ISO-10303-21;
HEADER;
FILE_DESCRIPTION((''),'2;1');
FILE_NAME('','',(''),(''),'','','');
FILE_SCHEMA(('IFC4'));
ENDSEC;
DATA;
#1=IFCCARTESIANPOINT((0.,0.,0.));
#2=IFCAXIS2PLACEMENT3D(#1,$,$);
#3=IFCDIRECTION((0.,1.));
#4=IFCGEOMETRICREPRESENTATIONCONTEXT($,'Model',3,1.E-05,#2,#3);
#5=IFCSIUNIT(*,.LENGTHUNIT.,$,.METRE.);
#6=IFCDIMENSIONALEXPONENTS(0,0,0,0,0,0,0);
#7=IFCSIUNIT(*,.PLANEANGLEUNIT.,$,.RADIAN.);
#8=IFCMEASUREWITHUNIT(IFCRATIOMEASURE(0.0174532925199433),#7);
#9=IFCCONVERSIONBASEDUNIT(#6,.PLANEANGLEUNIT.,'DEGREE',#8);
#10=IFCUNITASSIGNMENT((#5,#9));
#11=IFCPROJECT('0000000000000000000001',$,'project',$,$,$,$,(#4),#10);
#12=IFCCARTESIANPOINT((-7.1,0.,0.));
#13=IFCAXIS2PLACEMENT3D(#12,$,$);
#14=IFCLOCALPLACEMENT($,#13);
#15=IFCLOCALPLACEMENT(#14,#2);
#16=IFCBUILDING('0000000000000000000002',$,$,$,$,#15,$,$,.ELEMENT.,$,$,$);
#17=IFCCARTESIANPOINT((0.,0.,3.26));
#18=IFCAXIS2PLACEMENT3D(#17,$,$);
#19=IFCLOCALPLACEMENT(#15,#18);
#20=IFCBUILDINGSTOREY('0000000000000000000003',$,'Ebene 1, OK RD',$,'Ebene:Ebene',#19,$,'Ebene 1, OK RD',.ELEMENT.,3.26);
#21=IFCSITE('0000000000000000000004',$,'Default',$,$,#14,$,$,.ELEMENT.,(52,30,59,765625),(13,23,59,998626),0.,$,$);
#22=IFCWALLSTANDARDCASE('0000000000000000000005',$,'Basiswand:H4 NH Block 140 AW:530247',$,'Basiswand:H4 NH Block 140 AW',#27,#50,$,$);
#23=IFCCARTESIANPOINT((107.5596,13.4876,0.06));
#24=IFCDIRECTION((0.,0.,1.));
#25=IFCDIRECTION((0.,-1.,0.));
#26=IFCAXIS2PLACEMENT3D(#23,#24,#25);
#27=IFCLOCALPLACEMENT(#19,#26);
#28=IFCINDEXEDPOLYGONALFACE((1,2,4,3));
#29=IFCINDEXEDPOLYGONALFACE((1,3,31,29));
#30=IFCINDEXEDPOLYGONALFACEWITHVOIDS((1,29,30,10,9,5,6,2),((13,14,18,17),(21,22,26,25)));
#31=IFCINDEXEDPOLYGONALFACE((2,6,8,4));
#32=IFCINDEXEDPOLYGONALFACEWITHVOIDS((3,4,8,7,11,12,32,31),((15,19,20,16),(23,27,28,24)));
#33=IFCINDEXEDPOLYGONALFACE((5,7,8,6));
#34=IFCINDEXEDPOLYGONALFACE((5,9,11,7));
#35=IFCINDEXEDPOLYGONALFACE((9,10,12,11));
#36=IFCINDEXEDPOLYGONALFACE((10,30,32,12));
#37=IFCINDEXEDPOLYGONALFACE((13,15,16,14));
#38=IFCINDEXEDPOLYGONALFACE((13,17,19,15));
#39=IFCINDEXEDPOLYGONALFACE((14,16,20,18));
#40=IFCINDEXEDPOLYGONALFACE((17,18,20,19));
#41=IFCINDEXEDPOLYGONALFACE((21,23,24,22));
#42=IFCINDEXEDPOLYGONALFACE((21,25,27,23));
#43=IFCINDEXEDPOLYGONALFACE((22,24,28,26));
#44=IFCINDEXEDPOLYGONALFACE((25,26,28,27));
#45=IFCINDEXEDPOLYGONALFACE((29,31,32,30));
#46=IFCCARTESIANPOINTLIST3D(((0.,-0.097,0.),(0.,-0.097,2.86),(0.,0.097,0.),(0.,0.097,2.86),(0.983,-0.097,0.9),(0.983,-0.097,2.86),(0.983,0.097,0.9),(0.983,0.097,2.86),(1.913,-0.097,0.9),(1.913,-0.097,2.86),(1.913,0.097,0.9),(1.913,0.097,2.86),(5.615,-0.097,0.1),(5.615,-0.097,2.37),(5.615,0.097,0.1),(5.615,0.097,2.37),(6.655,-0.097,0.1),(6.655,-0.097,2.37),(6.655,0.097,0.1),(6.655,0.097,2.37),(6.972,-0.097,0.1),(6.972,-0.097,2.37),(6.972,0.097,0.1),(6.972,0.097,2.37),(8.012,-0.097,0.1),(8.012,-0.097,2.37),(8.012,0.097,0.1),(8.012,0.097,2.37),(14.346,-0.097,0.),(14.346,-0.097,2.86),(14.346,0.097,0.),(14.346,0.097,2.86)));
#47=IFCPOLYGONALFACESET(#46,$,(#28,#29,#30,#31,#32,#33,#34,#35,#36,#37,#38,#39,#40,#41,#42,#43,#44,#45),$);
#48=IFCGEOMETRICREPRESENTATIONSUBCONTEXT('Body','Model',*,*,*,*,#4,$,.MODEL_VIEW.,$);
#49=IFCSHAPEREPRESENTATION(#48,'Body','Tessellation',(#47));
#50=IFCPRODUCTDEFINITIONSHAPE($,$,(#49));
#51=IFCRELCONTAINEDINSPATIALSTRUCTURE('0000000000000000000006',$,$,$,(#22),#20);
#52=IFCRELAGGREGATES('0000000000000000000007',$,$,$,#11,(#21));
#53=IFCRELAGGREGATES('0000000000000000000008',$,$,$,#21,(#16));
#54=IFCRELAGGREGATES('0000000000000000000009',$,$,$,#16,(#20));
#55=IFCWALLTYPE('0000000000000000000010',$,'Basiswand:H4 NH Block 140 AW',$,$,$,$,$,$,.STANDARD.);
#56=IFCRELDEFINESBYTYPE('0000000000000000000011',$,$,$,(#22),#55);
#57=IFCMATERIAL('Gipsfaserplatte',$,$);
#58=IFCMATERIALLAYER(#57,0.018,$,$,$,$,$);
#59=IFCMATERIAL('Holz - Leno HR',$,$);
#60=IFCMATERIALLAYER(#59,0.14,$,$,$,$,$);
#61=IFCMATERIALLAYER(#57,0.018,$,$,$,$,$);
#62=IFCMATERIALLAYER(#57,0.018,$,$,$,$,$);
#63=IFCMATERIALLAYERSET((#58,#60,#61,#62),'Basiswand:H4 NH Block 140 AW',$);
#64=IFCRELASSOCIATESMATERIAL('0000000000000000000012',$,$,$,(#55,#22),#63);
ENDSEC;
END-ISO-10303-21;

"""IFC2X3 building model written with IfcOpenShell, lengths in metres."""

from ifc_helpers import new_model, entity, si_unit, converted_unit, direction, frame, frame_2d, origin, place, context, subcontext, project, spatial, rectangle, extrude, material, layer, layer_set, layer_usage, type_object, element, save


model = new_model("IFC2X3")

# Units and contexts
model_context = context("Model", 3, precision=1e-05, world=origin(), true_north=direction((0.0, 1.0)))
body_context = subcontext(model_context, "Body", "Model", "MODEL_VIEW")
ifc_project = project(units=[si_unit("LENGTHUNIT", "METRE"), converted_unit("PLANEANGLEUNIT", "DEGREE", entity("IfcRatioMeasure", 0.0174532925199433), si_unit("PLANEANGLEUNIT", "RADIAN"), dimensions=[0, 0, 0, 0, 0, 0, 0])], contexts=[model_context])

# Site, building, storey
site_placement = place(None, frame((-7.1, 0.0, 0.0)))
site = spatial("IfcSite", under=ifc_project, at=site_placement, Name="Default", CompositionType="ELEMENT", RefLatitude=(52, 30, 59, 765625), RefLongitude=(13, 23, 59, 998626), RefElevation=0.0)
building_placement = place(site_placement, origin())
building = spatial("IfcBuilding", under=site, at=building_placement, CompositionType="ELEMENT")
storey_placement = place(building_placement, frame((0.0, 0.0, 3.26)))
storey = spatial("IfcBuildingStorey", under=building, at=storey_placement, Name="Ebene 1, OK RD", ObjectType="Ebene:Ebene", LongName="Ebene 1, OK RD", CompositionType="ELEMENT", Elevation=3.26)

# Wall, openings
ifc_material_1 = material(Name="Gipsfaserplatte")
ifc_layer_1 = layer(ifc_material_1, 0.018)
ifc_material_2 = material(Name="Holz - Leno HR")
ifc_layer_2 = layer(ifc_material_2, 0.14)
ifc_layer_3 = layer(ifc_material_1, 0.018)
ifc_layer_4 = layer(ifc_material_1, 0.018)
ifc_layer_set_1 = layer_set([ifc_layer_1, ifc_layer_2, ifc_layer_3, ifc_layer_4], Name="Basiswand:H4 NH Block 140 AW")
ifc_layer_usage_1 = layer_usage(ifc_layer_set_1, "AXIS2", "NEGATIVE", 0.097)
wall_type_1 = type_object("IfcWallType", Name="Basiswand:H4 NH Block 140 AW", PredefinedType="STANDARD", material=ifc_layer_set_1)
wall_1_placement = place(storey_placement, frame((107.5596, 13.4876, 0.06), z_axis=(0.0, 0.0, 1.0), x_axis=(0.0, -1.0, 0.0)))
wall_1 = element("IfcWallStandardCase", 1, at=wall_1_placement, inside=storey, type_object=wall_type_1, material=ifc_layer_usage_1, Name="Basiswand:H4 NH Block 140 AW:530247", ObjectType="Basiswand:H4 NH Block 140 AW", context=body_context, shape_type="SweptSolid", body=[
    extrude(rectangle(XDim=14.346, YDim=0.194, at=frame_2d((7.173, 0.0), x_axis=(-1.0, 0.0))), origin(), (0.0, 0.0, 1.0), 2.86),
])
opening_1_placement = place(wall_1_placement, origin())
element("IfcOpeningElement", 2, at=opening_1_placement, cuts=wall_1, ObjectType="Opening", context=body_context, shape_type="SweptSolid", body=[
    extrude(rectangle(XDim=2.27, YDim=1.04, at=frame_2d((0.0, 0.0), x_axis=(1.0, 0.0))), frame((7.492, -0.097, 1.235), z_axis=(0.0, 1.0, 0.0), x_axis=(0.0, 0.0, -1.0)), (0.0, 0.0, 1.0), 0.194),
])
opening_2_placement = place(wall_1_placement, origin())
element("IfcOpeningElement", 3, at=opening_2_placement, cuts=wall_1, ObjectType="Opening", context=body_context, shape_type="SweptSolid", body=[
    extrude(rectangle(XDim=2.27, YDim=1.04, at=frame_2d((0.0, 0.0), x_axis=(1.0, 0.0))), frame((6.135, -0.097, 1.235), z_axis=(0.0, 1.0, 0.0), x_axis=(0.0, 0.0, -1.0)), (0.0, 0.0, 1.0), 0.194),
])
opening_3_placement = place(wall_1_placement, origin())
element("IfcOpeningElement", 4, at=opening_3_placement, cuts=wall_1, ObjectType="Opening", context=body_context, shape_type="SweptSolid", body=[
    extrude(rectangle(XDim=2.0, YDim=0.93, at=frame_2d((0.0, 0.0), x_axis=(1.0, 0.0))), frame((1.448, -0.097, 1.9), z_axis=(0.0, 1.0, 0.0), x_axis=(0.0, 0.0, -1.0)), (0.0, 0.0, 1.0), 0.194),
])

save(model, "model.ifc")
